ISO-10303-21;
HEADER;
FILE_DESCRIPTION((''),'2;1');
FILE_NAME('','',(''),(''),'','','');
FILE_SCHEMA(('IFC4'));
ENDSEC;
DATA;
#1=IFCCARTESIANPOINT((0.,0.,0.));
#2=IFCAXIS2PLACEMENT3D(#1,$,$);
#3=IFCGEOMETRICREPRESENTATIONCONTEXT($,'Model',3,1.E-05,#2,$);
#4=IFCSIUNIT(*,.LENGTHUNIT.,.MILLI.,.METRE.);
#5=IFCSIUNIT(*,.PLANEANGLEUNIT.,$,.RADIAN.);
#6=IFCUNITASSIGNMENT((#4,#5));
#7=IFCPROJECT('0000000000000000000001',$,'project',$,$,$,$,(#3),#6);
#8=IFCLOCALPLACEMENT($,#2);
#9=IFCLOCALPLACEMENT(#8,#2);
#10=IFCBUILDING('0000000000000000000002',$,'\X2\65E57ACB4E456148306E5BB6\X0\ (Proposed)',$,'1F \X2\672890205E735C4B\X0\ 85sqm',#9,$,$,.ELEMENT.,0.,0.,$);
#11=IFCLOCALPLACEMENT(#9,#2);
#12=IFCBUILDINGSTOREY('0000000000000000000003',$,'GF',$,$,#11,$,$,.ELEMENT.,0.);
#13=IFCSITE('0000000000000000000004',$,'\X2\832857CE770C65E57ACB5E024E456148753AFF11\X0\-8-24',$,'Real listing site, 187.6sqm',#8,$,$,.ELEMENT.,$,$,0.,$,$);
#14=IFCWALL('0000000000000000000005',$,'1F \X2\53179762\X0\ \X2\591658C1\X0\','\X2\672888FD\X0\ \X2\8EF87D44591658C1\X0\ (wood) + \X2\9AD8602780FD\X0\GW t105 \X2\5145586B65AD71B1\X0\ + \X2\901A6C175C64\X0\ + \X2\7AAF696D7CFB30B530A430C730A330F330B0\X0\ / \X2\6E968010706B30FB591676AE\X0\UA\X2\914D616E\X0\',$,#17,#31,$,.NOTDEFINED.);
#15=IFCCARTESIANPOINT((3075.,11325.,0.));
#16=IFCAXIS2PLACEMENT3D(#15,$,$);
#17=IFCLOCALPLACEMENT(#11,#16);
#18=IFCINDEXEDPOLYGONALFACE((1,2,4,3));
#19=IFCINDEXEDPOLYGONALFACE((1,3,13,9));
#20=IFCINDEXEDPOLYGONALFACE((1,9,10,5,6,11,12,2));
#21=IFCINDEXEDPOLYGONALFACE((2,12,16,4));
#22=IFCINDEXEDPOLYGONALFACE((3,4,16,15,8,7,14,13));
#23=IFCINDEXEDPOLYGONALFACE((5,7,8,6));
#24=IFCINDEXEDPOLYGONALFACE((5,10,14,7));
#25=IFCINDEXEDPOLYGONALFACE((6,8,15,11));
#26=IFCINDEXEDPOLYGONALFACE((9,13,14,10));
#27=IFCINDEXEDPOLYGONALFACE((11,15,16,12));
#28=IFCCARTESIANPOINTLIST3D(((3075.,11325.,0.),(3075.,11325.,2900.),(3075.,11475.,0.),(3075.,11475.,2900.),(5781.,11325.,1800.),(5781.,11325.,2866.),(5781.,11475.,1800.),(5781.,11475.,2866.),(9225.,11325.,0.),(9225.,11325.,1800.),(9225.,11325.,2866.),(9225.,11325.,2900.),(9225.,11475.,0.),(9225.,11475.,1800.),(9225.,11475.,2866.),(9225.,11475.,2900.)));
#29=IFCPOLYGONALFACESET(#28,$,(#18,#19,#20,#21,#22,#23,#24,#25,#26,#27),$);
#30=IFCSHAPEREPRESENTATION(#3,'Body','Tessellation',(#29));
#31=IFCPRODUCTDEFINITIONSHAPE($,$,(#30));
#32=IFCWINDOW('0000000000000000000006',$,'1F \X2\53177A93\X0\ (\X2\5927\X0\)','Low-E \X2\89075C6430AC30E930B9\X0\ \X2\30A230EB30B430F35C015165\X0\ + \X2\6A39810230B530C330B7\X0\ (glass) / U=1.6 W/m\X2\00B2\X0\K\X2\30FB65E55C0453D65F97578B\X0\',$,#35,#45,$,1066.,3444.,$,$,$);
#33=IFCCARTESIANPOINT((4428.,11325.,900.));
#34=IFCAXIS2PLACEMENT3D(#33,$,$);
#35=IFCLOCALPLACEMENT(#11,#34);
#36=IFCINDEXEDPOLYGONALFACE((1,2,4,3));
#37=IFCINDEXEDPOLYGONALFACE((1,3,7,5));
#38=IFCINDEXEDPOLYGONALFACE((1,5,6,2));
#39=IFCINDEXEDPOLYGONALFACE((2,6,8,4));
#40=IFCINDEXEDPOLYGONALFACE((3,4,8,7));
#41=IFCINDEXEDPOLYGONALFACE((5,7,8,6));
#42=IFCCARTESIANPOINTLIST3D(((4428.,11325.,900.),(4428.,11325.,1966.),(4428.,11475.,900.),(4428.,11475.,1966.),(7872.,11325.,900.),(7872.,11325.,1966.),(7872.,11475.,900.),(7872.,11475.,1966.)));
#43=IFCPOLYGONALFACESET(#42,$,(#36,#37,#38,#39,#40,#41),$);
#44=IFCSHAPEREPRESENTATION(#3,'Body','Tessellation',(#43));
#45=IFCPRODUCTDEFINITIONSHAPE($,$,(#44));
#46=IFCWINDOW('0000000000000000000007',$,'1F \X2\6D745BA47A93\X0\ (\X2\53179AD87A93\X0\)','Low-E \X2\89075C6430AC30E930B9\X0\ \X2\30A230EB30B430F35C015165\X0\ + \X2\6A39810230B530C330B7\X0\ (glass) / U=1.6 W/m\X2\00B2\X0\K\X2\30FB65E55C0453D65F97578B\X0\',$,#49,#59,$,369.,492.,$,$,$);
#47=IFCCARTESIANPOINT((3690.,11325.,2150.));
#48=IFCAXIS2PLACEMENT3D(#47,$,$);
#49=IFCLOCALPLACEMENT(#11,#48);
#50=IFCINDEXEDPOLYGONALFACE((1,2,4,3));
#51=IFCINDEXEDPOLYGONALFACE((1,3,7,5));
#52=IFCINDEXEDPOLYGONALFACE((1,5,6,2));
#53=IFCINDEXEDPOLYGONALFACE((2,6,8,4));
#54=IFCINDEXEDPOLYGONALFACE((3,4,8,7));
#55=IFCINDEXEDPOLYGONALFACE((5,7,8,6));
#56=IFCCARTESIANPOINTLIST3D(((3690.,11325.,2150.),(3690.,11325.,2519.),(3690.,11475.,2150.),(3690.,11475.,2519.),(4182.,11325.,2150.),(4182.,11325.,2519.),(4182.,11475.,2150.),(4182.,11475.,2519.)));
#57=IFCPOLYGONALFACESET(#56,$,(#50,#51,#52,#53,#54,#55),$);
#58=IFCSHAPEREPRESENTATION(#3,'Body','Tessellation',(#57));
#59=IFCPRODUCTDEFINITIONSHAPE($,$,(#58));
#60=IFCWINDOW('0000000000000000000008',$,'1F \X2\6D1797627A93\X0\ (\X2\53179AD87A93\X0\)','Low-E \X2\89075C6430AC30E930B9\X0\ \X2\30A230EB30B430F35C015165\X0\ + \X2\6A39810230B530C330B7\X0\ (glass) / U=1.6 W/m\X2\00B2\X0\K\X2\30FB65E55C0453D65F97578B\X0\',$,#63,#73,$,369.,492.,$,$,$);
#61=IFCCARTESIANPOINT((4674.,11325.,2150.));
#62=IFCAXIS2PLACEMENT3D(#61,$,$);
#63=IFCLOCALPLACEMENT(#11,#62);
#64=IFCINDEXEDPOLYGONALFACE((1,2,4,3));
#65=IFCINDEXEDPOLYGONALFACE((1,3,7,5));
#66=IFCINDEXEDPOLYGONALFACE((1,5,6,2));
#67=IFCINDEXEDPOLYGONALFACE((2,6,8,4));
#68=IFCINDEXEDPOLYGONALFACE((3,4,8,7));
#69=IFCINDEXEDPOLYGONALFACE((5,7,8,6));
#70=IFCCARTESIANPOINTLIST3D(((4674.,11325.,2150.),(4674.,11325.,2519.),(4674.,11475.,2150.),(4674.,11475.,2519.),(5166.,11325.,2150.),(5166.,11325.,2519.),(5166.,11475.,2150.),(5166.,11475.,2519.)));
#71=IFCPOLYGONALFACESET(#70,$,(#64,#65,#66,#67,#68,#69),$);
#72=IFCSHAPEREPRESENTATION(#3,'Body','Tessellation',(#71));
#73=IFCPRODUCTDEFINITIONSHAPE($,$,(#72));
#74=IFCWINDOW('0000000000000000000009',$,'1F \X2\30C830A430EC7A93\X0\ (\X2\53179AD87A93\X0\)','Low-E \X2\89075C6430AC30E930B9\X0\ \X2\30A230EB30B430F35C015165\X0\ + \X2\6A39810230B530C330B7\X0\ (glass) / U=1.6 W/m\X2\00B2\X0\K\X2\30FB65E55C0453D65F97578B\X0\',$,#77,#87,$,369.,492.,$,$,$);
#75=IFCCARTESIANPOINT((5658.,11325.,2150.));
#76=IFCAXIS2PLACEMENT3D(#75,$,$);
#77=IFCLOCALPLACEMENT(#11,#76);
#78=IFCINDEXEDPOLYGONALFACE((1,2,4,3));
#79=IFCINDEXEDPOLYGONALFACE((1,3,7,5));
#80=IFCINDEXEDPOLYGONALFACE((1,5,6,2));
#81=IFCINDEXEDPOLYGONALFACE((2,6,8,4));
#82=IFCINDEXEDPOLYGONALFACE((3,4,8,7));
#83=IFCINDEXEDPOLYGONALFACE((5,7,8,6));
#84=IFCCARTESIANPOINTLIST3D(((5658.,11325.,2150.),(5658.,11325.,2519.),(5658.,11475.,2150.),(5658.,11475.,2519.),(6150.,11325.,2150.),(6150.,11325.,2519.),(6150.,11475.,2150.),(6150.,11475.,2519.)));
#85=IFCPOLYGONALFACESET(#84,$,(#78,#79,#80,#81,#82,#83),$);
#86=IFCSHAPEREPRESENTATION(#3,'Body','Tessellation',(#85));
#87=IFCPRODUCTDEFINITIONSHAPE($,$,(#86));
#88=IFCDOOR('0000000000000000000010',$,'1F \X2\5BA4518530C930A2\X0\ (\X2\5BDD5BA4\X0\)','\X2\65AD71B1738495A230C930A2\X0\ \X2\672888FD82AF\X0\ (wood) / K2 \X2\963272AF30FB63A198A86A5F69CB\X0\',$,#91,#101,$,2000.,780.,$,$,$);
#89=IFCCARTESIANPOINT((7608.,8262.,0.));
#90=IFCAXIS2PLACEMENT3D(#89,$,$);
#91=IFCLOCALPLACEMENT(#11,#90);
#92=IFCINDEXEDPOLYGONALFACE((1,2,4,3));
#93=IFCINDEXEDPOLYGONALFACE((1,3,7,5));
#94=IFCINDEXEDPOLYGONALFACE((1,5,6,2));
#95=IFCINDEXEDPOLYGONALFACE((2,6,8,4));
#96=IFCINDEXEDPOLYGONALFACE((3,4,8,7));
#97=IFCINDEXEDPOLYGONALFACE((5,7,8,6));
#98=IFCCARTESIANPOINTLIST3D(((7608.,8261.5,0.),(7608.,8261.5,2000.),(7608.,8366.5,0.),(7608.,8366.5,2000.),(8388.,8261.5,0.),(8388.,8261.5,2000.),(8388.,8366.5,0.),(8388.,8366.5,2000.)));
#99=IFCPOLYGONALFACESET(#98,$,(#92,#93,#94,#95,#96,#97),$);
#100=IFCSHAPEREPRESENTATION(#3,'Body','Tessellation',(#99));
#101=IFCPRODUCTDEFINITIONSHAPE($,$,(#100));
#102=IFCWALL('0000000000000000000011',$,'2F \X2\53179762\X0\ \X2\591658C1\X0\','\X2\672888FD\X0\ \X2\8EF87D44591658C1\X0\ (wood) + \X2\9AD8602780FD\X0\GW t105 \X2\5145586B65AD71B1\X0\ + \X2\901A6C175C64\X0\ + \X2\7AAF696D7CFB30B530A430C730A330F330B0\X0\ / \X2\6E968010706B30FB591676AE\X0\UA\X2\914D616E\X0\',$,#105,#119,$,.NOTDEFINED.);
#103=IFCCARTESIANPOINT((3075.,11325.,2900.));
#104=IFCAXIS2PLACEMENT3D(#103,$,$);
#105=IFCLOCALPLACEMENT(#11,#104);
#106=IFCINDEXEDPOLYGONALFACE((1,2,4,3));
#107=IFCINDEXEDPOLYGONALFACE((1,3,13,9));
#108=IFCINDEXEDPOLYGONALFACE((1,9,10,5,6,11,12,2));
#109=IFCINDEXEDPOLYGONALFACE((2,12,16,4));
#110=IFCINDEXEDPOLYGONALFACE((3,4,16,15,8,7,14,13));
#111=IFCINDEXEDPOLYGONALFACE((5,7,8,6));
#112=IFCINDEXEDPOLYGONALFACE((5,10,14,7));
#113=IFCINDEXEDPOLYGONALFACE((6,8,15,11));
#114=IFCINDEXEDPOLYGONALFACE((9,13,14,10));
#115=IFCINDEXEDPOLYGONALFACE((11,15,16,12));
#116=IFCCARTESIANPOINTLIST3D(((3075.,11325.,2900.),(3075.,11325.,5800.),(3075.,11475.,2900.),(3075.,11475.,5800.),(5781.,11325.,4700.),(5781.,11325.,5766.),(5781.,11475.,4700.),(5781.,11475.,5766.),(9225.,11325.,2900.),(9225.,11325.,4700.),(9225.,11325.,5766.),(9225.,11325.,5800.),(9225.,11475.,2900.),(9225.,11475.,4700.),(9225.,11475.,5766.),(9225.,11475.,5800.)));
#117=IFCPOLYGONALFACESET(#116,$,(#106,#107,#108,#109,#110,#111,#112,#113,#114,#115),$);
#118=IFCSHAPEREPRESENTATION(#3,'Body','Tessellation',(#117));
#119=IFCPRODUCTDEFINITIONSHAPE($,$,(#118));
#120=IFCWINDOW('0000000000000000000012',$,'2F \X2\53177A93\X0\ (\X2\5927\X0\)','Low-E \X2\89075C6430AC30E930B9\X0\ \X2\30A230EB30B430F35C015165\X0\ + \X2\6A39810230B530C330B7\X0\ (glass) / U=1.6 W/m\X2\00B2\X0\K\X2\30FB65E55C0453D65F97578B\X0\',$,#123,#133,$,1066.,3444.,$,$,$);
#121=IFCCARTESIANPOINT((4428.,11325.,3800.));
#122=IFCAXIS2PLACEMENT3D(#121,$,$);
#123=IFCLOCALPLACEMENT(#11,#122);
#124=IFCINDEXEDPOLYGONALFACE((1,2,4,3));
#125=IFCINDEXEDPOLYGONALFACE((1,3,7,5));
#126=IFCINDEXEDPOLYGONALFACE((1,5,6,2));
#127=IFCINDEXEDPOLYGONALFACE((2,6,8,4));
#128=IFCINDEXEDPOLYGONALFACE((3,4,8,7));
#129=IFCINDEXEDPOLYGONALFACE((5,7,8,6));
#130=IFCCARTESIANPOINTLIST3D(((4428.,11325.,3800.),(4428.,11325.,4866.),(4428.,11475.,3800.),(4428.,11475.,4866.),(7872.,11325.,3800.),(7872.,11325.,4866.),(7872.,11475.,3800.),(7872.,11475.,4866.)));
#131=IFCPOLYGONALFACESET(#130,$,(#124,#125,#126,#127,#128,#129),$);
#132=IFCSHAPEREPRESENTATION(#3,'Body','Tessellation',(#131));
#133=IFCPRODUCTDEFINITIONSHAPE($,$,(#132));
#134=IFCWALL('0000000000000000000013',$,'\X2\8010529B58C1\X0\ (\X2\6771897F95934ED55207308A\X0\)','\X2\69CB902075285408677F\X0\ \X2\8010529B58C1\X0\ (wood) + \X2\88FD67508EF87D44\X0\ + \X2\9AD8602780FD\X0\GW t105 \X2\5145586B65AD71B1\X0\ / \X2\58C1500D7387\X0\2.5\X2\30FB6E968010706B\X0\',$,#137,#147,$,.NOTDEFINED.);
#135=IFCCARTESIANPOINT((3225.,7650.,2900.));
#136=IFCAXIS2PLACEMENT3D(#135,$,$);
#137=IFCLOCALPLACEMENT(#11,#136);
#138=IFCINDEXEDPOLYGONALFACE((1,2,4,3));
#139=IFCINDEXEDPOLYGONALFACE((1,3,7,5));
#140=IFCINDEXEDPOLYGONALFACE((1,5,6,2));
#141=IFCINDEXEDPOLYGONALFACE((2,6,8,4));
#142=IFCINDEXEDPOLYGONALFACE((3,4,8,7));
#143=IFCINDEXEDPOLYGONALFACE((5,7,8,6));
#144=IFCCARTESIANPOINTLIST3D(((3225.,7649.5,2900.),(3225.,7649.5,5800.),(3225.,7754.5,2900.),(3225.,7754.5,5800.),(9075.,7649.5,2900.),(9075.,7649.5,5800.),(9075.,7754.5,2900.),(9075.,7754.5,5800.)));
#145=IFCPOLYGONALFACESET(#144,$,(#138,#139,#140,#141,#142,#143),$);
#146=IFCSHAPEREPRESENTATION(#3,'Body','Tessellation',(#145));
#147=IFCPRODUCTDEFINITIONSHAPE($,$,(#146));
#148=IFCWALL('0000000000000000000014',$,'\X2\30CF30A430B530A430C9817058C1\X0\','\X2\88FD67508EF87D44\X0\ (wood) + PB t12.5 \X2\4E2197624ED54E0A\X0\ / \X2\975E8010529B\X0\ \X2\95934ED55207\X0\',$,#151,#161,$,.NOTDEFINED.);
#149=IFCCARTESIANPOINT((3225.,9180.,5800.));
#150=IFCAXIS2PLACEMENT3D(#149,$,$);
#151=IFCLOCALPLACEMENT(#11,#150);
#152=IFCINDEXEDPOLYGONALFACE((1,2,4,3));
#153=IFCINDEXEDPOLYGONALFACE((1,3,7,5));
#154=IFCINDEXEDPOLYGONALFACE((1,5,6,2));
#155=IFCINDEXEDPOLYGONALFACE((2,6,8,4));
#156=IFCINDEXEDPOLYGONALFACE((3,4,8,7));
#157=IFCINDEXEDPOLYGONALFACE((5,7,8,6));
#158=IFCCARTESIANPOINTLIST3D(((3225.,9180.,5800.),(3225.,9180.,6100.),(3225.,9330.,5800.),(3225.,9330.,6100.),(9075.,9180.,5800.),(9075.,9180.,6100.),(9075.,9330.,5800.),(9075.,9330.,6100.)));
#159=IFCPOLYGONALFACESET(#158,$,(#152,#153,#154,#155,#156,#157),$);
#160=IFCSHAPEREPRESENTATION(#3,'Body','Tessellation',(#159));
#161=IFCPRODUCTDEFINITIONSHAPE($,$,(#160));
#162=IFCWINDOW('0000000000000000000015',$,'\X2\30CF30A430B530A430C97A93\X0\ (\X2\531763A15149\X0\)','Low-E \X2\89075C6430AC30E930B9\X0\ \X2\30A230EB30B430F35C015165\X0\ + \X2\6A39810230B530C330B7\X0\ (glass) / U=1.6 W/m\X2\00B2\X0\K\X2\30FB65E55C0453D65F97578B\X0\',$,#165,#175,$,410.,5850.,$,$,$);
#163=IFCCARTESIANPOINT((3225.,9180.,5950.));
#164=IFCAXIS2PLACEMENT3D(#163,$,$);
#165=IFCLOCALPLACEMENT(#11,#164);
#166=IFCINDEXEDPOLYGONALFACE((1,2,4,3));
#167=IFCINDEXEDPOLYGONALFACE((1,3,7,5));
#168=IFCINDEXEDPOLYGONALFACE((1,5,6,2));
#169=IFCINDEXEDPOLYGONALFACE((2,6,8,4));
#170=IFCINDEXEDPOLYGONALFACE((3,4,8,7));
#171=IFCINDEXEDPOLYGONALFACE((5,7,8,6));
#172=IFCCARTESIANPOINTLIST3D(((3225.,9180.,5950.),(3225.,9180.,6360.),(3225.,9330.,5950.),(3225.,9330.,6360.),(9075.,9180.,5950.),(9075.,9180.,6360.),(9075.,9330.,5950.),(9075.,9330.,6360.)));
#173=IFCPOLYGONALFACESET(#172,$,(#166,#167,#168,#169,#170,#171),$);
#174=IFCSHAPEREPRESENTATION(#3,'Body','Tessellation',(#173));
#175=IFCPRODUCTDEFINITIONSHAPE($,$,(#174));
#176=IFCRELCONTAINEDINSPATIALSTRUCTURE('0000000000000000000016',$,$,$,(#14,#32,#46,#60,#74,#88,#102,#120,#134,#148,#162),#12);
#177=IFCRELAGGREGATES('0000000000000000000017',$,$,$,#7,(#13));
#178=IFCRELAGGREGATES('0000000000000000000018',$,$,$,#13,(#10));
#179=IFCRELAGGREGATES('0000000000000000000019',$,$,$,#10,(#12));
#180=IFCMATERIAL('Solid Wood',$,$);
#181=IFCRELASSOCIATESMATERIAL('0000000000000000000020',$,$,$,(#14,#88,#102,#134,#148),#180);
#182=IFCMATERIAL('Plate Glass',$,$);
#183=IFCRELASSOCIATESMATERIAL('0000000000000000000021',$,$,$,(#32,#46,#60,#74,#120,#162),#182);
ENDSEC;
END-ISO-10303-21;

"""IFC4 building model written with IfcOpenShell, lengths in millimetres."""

from ifc_helpers import new_model, si_unit, frame, frame_2d, origin, place, context, project, spatial, rectangle, extrude, material, element, fill, save


model = new_model("IFC4")

# Units and contexts
model_context = context("Model", 3, precision=1e-05, world=origin())
ifc_project = project(units=[si_unit("LENGTHUNIT", "METRE", prefix="MILLI"), si_unit("PLANEANGLEUNIT", "RADIAN")], contexts=[model_context])

# Site, building, storey
site_placement = place(None, origin())
site = spatial("IfcSite", under=ifc_project, at=site_placement, Name="茨城県日立市久慈町１-8-24", ObjectType="Real listing site, 187.6sqm", CompositionType="ELEMENT", RefElevation=0.0)
building_placement = place(site_placement, origin())
building = spatial("IfcBuilding", under=site, at=building_placement, Name="日立久慈の家 (Proposed)", ObjectType="1F 木造平屋 85sqm", CompositionType="ELEMENT", ElevationOfRefHeight=0.0, ElevationOfTerrain=0.0)
storey_placement = place(building_placement, origin())
storey = spatial("IfcBuildingStorey", under=building, at=storey_placement, Name="GF", CompositionType="ELEMENT", Elevation=0.0)

# Wall, openings, windows
ifc_material_1 = material(Name="Solid Wood")
wall_1_placement = place(storey_placement, frame((3075.0, 11325.0, 0.0)))
wall_1 = element("IfcWall", 1, at=wall_1_placement, inside=storey, material=ifc_material_1, Name="1F 北面 外壁", Description="木製 軸組外壁 (wood) + 高性能GW t105 充填断熱 + 通気層 + 窯業系サイディング / 準耐火・外皮UA配慮", PredefinedType="NOTDEFINED", context=model_context, shape_type="SweptSolid", body=[
    extrude(rectangle(XDim=6150.0, YDim=150.0, at=frame_2d((3075.0, 75.0))), frame((3075.0, 11325.0, 0.0)), (0.0, 0.0, 1.0), 2900.0),
])
opening_1_placement = place(storey_placement, frame((4428.0, 11325.0, 900.0)))
opening_1 = element("IfcOpeningElement", 2, at=opening_1_placement, cuts=wall_1, PredefinedType="NOTDEFINED", context=model_context, shape_type="SweptSolid", body=[
    extrude(rectangle(XDim=3444.0, YDim=150.0, at=frame_2d((1722.0, 75.0))), frame((4428.0, 11325.0, 900.0)), (0.0, 0.0, 1.0), 1066.0),
])
opening_2_placement = place(storey_placement, frame((3690.0, 11325.0, 2150.0)))
opening_2 = element("IfcOpeningElement", 3, at=opening_2_placement, cuts=wall_1, PredefinedType="NOTDEFINED", context=model_context, shape_type="SweptSolid", body=[
    extrude(rectangle(XDim=492.0, YDim=150.0, at=frame_2d((246.0, 75.0))), frame((3690.0, 11325.0, 2150.0)), (0.0, 0.0, 1.0), 369.0),
])
opening_3_placement = place(storey_placement, frame((4674.0, 11325.0, 2150.0)))
opening_3 = element("IfcOpeningElement", 4, at=opening_3_placement, cuts=wall_1, PredefinedType="NOTDEFINED", context=model_context, shape_type="SweptSolid", body=[
    extrude(rectangle(XDim=492.0, YDim=150.0, at=frame_2d((246.0, 75.0))), frame((4674.0, 11325.0, 2150.0)), (0.0, 0.0, 1.0), 369.0),
])
opening_4_placement = place(storey_placement, frame((5658.0, 11325.0, 2150.0)))
opening_4 = element("IfcOpeningElement", 5, at=opening_4_placement, cuts=wall_1, PredefinedType="NOTDEFINED", context=model_context, shape_type="SweptSolid", body=[
    extrude(rectangle(XDim=492.0, YDim=150.0, at=frame_2d((246.0, 75.0))), frame((5658.0, 11325.0, 2150.0)), (0.0, 0.0, 1.0), 369.0),
])
ifc_material_2 = material(Name="Plate Glass")
window_1_placement = place(storey_placement, frame((4428.0, 11325.0, 900.0)))
window_1 = element("IfcWindow", 6, at=window_1_placement, inside=storey, material=ifc_material_2, Name="1F 北窓 (大)", Description="Low-E 複層ガラス アルゴン封入 + 樹脂サッシ (glass) / U=1.6 W/m²K・日射取得型", OverallHeight=1066.0, OverallWidth=3444.0, context=model_context, shape_type="SweptSolid", body=[
    extrude(rectangle(XDim=3444.0, YDim=150.0, at=frame_2d((1722.0, 75.0))), frame((4428.0, 11325.0, 900.0)), (0.0, 0.0, 1.0), 1066.0),
])
fill(opening_1, window_1)
window_2_placement = place(storey_placement, frame((3690.0, 11325.0, 2150.0)))
window_2 = element("IfcWindow", 7, at=window_2_placement, inside=storey, material=ifc_material_2, Name="1F 浴室窓 (北高窓)", Description="Low-E 複層ガラス アルゴン封入 + 樹脂サッシ (glass) / U=1.6 W/m²K・日射取得型", OverallHeight=369.0, OverallWidth=492.0, context=model_context, shape_type="SweptSolid", body=[
    extrude(rectangle(XDim=492.0, YDim=150.0, at=frame_2d((246.0, 75.0))), frame((3690.0, 11325.0, 2150.0)), (0.0, 0.0, 1.0), 369.0),
])
fill(opening_2, window_2)
window_3_placement = place(storey_placement, frame((4674.0, 11325.0, 2150.0)))
window_3 = element("IfcWindow", 8, at=window_3_placement, inside=storey, material=ifc_material_2, Name="1F 洗面窓 (北高窓)", Description="Low-E 複層ガラス アルゴン封入 + 樹脂サッシ (glass) / U=1.6 W/m²K・日射取得型", OverallHeight=369.0, OverallWidth=492.0, context=model_context, shape_type="SweptSolid", body=[
    extrude(rectangle(XDim=492.0, YDim=150.0, at=frame_2d((246.0, 75.0))), frame((4674.0, 11325.0, 2150.0)), (0.0, 0.0, 1.0), 369.0),
])
fill(opening_3, window_3)
window_4_placement = place(storey_placement, frame((5658.0, 11325.0, 2150.0)))
window_4 = element("IfcWindow", 9, at=window_4_placement, inside=storey, material=ifc_material_2, Name="1F トイレ窓 (北高窓)", Description="Low-E 複層ガラス アルゴン封入 + 樹脂サッシ (glass) / U=1.6 W/m²K・日射取得型", OverallHeight=369.0, OverallWidth=492.0, context=model_context, shape_type="SweptSolid", body=[
    extrude(rectangle(XDim=492.0, YDim=150.0, at=frame_2d((246.0, 75.0))), frame((5658.0, 11325.0, 2150.0)), (0.0, 0.0, 1.0), 369.0),
])
fill(opening_4, window_4)

# Door
door_1_placement = place(storey_placement, frame((7608.0, 8262.0, 0.0)))
element("IfcDoor", 10, at=door_1_placement, inside=storey, material=ifc_material_1, Name="1F 室内ドア (寝室)", Description="断熱玄関ドア 木製芯 (wood) / K2 防犯・採風機構", OverallHeight=2000.0, OverallWidth=780.0, context=model_context, shape_type="SweptSolid", body=[
    extrude(rectangle(XDim=780.0, YDim=105.0, at=frame_2d((390.0, 52.0))), frame((7608.0, 8262.0, 0.0)), (0.0, 0.0, 1.0), 2000.0),
])

# Wall, opening, window
wall_2_placement = place(storey_placement, frame((3075.0, 11325.0, 2900.0)))
wall_2 = element("IfcWall", 11, at=wall_2_placement, inside=storey, material=ifc_material_1, Name="2F 北面 外壁", Description="木製 軸組外壁 (wood) + 高性能GW t105 充填断熱 + 通気層 + 窯業系サイディング / 準耐火・外皮UA配慮", PredefinedType="NOTDEFINED", context=model_context, shape_type="SweptSolid", body=[
    extrude(rectangle(XDim=6150.0, YDim=150.0, at=frame_2d((3075.0, 75.0))), frame((3075.0, 11325.0, 2900.0)), (0.0, 0.0, 1.0), 2900.0),
])
opening_5_placement = place(storey_placement, frame((4428.0, 11325.0, 3800.0)))
opening_5 = element("IfcOpeningElement", 12, at=opening_5_placement, cuts=wall_2, PredefinedType="NOTDEFINED", context=model_context, shape_type="SweptSolid", body=[
    extrude(rectangle(XDim=3444.0, YDim=150.0, at=frame_2d((1722.0, 75.0))), frame((4428.0, 11325.0, 3800.0)), (0.0, 0.0, 1.0), 1066.0),
])
window_5_placement = place(storey_placement, frame((4428.0, 11325.0, 3800.0)))
window_5 = element("IfcWindow", 13, at=window_5_placement, inside=storey, material=ifc_material_2, Name="2F 北窓 (大)", Description="Low-E 複層ガラス アルゴン封入 + 樹脂サッシ (glass) / U=1.6 W/m²K・日射取得型", OverallHeight=1066.0, OverallWidth=3444.0, context=model_context, shape_type="SweptSolid", body=[
    extrude(rectangle(XDim=3444.0, YDim=150.0, at=frame_2d((1722.0, 75.0))), frame((4428.0, 11325.0, 3800.0)), (0.0, 0.0, 1.0), 1066.0),
])
fill(opening_5, window_5)

# Wall
wall_3_placement = place(storey_placement, frame((3225.0, 7650.0, 2900.0)))
element("IfcWall", 14, at=wall_3_placement, inside=storey, material=ifc_material_1, Name="耐力壁 (東西間仕切り)", Description="構造用合板 耐力壁 (wood) + 製材軸組 + 高性能GW t105 充填断熱 / 壁倍率2.5・準耐火", PredefinedType="NOTDEFINED", context=model_context, shape_type="SweptSolid", body=[
    extrude(rectangle(XDim=5850.0, YDim=105.0, at=frame_2d((2925.0, 52.0))), frame((3225.0, 7650.0, 2900.0)), (0.0, 0.0, 1.0), 2900.0),
])

# Wall, opening, window
wall_4_placement = place(storey_placement, frame((3225.0, 9180.0, 5800.0)))
wall_4 = element("IfcWall", 15, at=wall_4_placement, inside=storey, material=ifc_material_1, Name="ハイサイド腰壁", Description="製材軸組 (wood) + PB t12.5 両面仕上 / 非耐力 間仕切", PredefinedType="NOTDEFINED", context=model_context, shape_type="SweptSolid", body=[
    extrude(rectangle(XDim=5850.0, YDim=150.0, at=frame_2d((2925.0, 75.0))), frame((3225.0, 9180.0, 5800.0)), (0.0, 0.0, 1.0), 700.0),
])
opening_6_placement = place(storey_placement, frame((3225.0, 9180.0, 5950.0)))
opening_6 = element("IfcOpeningElement", 16, at=opening_6_placement, cuts=wall_4, PredefinedType="NOTDEFINED", context=model_context, shape_type="SweptSolid", body=[
    extrude(rectangle(XDim=5850.0, YDim=150.0, at=frame_2d((2925.0, 75.0))), frame((3225.0, 9180.0, 5950.0)), (0.0, 0.0, 1.0), 410.0),
])
window_6_placement = place(storey_placement, frame((3225.0, 9180.0, 5950.0)))
window_6 = element("IfcWindow", 17, at=window_6_placement, inside=storey, material=ifc_material_2, Name="ハイサイド窓 (北採光)", Description="Low-E 複層ガラス アルゴン封入 + 樹脂サッシ (glass) / U=1.6 W/m²K・日射取得型", OverallHeight=410.0, OverallWidth=5850.0, context=model_context, shape_type="SweptSolid", body=[
    extrude(rectangle(XDim=5850.0, YDim=150.0, at=frame_2d((2925.0, 75.0))), frame((3225.0, 9180.0, 5950.0)), (0.0, 0.0, 1.0), 410.0),
])
fill(opening_6, window_6)

save(model, "model.ifc")
